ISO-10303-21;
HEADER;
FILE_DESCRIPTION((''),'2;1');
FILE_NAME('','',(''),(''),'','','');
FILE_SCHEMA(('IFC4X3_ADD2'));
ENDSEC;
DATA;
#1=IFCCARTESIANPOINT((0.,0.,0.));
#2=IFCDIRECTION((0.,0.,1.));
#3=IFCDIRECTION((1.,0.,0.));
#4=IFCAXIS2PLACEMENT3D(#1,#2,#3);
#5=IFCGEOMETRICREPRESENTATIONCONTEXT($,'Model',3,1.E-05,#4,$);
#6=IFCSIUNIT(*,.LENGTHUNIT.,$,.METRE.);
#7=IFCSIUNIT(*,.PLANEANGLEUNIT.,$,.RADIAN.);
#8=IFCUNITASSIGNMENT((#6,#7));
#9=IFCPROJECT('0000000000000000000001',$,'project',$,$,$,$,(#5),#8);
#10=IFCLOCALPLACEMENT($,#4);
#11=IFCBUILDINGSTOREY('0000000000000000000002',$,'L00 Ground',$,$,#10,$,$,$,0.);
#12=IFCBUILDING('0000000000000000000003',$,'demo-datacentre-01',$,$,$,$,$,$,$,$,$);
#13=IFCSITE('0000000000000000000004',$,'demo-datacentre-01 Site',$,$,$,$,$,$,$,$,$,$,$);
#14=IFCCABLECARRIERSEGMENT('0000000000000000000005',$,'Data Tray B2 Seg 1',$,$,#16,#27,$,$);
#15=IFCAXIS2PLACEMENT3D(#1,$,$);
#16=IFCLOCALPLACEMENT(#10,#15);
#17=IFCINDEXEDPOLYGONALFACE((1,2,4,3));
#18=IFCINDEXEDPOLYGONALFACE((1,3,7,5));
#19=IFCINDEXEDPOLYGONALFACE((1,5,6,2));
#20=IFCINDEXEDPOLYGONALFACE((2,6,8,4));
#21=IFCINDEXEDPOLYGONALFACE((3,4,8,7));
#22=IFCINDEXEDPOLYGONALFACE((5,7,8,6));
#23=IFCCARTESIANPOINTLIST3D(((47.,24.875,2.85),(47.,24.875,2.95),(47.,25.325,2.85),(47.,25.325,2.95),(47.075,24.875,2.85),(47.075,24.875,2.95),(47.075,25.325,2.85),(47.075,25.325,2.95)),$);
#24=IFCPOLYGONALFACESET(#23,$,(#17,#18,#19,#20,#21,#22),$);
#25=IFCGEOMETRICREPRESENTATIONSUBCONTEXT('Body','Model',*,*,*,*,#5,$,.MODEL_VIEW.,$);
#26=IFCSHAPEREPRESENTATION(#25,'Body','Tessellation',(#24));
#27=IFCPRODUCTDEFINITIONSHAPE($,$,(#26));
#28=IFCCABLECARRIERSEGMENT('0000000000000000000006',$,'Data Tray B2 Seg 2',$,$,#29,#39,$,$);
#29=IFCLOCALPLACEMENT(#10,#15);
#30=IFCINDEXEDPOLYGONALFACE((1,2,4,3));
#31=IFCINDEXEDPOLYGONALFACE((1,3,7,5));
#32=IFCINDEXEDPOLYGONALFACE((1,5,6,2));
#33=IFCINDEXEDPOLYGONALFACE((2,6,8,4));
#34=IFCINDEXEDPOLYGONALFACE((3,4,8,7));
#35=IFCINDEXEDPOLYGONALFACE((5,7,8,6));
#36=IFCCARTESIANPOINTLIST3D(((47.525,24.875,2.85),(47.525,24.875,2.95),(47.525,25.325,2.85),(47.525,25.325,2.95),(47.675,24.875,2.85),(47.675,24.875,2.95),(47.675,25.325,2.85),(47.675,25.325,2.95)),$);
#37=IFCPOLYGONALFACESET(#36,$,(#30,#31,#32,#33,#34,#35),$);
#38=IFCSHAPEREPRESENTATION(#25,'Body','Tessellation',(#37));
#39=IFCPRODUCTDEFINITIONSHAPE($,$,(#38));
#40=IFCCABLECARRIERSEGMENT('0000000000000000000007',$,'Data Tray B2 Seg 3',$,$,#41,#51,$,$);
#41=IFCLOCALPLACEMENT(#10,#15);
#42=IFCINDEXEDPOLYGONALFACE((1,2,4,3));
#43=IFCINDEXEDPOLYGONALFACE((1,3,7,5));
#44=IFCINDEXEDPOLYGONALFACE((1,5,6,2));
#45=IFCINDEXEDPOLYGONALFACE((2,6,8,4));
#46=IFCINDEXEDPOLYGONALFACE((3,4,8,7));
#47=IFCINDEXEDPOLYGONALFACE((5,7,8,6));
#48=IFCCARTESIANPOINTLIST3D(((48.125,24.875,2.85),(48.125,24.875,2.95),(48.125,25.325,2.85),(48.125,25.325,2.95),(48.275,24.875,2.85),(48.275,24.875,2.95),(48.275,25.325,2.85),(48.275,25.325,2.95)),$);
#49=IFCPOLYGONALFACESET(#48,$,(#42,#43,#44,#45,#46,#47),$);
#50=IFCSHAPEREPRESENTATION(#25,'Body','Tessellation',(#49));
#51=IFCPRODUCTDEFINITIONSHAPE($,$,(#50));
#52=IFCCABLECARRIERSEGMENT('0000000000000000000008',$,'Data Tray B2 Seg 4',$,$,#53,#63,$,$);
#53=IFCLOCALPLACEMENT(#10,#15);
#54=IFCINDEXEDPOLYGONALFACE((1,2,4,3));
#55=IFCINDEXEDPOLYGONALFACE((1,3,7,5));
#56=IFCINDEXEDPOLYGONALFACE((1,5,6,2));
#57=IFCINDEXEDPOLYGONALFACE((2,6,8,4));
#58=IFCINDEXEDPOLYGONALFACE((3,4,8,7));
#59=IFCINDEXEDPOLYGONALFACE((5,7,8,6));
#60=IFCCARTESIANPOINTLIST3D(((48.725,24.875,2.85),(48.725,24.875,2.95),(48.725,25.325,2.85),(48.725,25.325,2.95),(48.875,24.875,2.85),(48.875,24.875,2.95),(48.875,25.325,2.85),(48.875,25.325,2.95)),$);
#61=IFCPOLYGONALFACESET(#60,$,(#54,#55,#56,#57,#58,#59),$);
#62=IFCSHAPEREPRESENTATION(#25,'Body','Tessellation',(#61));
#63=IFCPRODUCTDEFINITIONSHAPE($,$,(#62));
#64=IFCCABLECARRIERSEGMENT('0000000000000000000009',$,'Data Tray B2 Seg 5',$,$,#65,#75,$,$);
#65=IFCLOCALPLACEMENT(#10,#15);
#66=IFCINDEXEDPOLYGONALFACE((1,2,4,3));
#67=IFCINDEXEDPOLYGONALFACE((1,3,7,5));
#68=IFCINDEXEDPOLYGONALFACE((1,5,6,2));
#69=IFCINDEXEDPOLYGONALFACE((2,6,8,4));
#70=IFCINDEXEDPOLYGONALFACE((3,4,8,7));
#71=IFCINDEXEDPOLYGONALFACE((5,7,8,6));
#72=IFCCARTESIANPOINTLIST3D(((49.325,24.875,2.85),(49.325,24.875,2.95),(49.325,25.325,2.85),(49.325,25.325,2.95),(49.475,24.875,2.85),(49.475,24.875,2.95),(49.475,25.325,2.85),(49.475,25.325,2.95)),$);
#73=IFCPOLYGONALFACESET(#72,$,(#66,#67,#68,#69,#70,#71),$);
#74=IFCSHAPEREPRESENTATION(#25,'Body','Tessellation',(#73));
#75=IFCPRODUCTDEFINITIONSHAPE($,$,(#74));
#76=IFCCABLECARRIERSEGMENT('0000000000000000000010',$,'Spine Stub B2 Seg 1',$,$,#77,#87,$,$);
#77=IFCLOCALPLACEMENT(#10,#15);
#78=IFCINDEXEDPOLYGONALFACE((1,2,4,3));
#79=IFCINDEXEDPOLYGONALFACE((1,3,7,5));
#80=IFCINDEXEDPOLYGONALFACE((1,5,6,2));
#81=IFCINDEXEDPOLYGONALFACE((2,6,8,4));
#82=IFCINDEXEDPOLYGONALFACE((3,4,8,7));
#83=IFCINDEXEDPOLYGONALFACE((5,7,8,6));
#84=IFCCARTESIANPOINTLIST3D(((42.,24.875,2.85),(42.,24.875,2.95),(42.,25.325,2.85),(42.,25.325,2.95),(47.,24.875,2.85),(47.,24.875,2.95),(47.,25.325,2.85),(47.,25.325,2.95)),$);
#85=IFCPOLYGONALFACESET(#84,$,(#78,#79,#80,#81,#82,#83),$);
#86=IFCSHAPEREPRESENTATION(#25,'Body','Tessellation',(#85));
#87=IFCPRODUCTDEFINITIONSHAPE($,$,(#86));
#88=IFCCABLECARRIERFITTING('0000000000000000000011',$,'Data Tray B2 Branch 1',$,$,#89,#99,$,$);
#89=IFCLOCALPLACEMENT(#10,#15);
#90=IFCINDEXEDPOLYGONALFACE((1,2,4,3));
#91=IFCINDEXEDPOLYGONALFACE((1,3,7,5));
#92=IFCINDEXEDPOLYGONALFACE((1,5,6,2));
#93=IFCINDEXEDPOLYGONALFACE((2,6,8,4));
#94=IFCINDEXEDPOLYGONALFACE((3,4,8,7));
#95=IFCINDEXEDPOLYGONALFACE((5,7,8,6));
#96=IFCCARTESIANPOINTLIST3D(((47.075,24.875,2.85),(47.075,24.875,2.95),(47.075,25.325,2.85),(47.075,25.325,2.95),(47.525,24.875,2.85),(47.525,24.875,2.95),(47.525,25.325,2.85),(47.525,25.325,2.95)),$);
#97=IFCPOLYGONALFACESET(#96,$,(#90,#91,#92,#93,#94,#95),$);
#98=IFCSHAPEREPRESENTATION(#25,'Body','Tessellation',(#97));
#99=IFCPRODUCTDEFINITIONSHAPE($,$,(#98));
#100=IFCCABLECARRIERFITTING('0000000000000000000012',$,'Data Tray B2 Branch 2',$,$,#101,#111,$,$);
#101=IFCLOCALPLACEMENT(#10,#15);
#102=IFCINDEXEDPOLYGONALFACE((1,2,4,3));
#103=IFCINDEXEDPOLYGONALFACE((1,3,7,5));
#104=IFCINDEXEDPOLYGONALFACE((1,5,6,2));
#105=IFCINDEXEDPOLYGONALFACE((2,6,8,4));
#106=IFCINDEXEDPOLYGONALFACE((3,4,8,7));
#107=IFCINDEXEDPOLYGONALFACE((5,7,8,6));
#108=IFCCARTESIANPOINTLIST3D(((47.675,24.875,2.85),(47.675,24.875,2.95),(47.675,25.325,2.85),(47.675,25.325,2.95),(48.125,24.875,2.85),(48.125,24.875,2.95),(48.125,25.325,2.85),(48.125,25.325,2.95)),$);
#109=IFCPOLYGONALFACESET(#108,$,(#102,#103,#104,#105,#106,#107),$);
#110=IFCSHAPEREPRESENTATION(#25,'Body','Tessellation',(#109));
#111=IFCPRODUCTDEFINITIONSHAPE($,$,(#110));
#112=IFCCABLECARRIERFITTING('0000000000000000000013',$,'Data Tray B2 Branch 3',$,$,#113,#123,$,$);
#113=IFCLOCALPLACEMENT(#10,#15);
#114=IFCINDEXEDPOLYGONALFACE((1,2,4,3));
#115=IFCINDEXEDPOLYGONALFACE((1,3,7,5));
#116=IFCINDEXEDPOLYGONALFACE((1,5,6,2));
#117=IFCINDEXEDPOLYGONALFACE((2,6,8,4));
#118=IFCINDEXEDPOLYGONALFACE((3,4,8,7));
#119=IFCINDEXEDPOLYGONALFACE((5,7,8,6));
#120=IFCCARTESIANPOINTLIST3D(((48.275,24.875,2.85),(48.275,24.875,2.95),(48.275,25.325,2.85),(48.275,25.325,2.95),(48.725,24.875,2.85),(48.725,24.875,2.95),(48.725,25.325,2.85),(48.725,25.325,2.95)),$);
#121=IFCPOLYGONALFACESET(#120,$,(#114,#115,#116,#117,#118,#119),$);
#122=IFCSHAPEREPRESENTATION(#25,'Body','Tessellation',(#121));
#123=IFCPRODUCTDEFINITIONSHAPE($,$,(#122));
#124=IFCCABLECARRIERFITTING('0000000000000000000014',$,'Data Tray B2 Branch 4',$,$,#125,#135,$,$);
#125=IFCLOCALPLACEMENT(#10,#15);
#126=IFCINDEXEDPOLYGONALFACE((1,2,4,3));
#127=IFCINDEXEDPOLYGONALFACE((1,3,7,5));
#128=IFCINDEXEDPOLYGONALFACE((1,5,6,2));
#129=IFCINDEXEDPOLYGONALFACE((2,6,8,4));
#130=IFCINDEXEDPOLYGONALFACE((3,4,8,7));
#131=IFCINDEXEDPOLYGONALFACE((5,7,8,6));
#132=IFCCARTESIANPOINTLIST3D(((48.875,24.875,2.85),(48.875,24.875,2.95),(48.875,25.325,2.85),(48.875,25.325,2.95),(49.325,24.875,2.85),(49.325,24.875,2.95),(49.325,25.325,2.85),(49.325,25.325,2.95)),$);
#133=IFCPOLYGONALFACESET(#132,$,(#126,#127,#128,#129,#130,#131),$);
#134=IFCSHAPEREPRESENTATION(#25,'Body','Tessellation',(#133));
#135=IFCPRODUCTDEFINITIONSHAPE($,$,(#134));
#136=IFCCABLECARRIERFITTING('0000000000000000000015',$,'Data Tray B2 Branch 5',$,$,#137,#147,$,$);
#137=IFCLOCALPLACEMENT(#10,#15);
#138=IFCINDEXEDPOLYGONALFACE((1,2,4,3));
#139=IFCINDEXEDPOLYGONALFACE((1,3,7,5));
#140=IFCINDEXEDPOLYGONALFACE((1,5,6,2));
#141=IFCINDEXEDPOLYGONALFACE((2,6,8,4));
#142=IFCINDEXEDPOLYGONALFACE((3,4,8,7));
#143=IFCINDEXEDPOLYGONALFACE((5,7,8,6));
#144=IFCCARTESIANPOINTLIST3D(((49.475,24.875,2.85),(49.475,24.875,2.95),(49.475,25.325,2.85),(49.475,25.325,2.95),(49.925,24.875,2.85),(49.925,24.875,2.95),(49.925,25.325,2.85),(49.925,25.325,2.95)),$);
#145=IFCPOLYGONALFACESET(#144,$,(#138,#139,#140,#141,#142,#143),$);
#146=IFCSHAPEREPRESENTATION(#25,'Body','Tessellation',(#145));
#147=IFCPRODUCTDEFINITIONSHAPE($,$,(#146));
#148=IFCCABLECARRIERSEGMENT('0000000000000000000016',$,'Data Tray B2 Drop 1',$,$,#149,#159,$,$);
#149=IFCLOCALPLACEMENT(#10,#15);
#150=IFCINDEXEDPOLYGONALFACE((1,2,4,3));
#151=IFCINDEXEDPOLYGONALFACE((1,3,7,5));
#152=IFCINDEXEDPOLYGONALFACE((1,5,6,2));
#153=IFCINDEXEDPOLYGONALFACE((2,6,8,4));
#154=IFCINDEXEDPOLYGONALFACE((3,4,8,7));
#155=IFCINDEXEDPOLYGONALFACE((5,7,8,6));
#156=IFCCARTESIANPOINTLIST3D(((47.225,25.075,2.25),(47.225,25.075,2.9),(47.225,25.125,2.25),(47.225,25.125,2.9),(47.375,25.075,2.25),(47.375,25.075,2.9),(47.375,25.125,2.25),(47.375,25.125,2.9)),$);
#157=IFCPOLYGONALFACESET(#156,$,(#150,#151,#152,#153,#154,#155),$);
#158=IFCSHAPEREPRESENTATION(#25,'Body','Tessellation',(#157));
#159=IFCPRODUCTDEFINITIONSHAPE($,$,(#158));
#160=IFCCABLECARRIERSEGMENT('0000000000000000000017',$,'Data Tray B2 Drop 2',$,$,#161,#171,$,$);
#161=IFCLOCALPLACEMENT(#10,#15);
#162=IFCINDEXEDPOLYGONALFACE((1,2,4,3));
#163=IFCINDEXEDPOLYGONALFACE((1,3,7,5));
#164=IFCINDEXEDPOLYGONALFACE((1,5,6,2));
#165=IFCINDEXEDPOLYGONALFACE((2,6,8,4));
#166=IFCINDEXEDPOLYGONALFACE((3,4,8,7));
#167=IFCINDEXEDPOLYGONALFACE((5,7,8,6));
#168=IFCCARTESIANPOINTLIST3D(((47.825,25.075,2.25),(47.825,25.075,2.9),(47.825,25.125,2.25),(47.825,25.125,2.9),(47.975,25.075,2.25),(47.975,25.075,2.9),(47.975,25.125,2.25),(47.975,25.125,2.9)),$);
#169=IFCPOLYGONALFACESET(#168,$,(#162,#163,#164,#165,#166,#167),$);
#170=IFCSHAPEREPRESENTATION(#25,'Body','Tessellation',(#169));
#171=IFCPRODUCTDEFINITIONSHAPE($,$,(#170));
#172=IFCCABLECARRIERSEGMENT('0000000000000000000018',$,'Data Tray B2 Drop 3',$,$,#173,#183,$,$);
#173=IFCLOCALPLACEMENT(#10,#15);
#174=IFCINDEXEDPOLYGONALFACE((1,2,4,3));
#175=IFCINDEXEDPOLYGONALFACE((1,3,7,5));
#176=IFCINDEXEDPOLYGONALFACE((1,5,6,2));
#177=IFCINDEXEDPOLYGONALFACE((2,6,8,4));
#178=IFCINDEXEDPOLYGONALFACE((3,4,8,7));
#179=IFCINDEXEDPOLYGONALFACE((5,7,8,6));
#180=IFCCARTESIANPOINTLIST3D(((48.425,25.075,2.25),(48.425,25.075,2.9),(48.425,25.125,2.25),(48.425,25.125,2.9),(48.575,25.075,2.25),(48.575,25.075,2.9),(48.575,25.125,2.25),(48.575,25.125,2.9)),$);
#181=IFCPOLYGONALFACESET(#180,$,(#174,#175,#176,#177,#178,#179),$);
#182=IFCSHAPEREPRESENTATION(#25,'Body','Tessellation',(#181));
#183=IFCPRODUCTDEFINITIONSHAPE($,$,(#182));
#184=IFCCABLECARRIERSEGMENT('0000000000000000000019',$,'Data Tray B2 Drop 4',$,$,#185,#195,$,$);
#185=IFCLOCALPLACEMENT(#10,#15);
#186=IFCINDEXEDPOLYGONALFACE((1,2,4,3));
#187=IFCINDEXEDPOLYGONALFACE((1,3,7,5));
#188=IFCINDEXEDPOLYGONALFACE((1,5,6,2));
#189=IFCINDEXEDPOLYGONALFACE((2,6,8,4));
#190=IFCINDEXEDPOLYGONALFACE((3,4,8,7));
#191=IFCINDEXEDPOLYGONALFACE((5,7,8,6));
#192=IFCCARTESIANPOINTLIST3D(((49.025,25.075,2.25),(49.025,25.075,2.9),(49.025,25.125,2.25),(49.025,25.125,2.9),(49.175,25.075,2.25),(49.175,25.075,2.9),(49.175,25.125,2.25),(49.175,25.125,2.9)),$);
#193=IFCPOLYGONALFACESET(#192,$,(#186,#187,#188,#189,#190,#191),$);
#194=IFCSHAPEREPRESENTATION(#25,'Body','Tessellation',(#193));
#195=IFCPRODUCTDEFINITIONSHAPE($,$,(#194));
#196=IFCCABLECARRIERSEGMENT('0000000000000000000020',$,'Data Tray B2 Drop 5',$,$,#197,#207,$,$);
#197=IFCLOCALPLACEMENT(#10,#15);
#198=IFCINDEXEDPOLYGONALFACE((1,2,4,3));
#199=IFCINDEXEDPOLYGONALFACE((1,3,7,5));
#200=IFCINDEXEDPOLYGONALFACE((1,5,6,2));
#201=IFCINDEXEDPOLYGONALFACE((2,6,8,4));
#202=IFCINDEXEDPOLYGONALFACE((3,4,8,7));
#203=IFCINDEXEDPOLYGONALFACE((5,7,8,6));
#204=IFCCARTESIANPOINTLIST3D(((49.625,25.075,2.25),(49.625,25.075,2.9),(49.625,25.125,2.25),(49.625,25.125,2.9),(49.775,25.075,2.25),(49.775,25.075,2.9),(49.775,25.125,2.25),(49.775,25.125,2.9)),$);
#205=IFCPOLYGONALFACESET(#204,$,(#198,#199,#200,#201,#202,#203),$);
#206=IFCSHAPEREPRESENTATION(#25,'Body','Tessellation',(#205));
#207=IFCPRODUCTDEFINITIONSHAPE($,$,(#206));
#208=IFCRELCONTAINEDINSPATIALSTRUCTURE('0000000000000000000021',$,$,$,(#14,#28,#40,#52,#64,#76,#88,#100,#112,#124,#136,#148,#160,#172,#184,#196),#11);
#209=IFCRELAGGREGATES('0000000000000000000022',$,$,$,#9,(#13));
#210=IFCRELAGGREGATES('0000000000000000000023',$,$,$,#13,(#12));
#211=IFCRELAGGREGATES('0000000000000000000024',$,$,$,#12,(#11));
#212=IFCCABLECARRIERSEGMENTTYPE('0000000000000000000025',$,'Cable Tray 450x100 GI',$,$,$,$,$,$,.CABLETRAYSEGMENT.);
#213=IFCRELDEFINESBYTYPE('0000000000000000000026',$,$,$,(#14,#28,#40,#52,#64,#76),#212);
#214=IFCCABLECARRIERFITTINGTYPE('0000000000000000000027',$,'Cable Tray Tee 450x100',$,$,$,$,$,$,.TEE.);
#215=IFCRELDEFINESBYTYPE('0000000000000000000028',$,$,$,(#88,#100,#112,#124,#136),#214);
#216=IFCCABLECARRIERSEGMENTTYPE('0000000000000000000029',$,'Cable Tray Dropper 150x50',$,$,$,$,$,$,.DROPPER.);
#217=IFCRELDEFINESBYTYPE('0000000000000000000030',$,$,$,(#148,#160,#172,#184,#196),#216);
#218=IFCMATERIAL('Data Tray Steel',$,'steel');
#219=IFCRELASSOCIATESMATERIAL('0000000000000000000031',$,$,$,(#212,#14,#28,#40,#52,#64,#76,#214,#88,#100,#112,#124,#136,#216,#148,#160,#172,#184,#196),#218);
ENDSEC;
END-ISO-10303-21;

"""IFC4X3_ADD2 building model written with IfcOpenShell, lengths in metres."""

from ifc_helpers import new_model, si_unit, frame, origin_with_axes, place, context, subcontext, project, spatial, rectangle, extrude, material, type_object, element, save


model = new_model("IFC4X3_ADD2")

# Units and contexts
model_context = context("Model", 3, precision=1e-05, world=origin_with_axes())
body_context = subcontext(model_context, "Body", "Model", "MODEL_VIEW")
ifc_project = project(units=[si_unit("LENGTHUNIT", "METRE"), si_unit("PLANEANGLEUNIT", "RADIAN")], contexts=[model_context])

# Site, building, storey
site = spatial("IfcSite", under=ifc_project, Name="demo-datacentre-01 Site")
building = spatial("IfcBuilding", under=site, Name="demo-datacentre-01")
storey_placement = place(None, origin_with_axes())
storey = spatial("IfcBuildingStorey", under=building, at=storey_placement, Name="L00 Ground", Elevation=0.0)

# Cable carrier segments
ifc_material_1 = material(Name="Data Tray Steel", Category="steel")
cable_carrier_segment_type_1 = type_object("IfcCableCarrierSegmentType", Name="Cable Tray 450x100 GI", PredefinedType="CABLETRAYSEGMENT", material=ifc_material_1)
cable_carrier_segment_1_placement = place(storey_placement, frame((47.0, 25.1, 2.9), z_axis=(1.0, 0.0, 0.0), x_axis=(0.0, 1.0, 0.0)))
element("IfcCableCarrierSegment", 1, at=cable_carrier_segment_1_placement, inside=storey, type_object=cable_carrier_segment_type_1, material=ifc_material_1, Name="Data Tray B2 Seg 1", context=body_context, shape_type="SweptSolid", body=[
    extrude(rectangle(XDim=0.45, YDim=0.1), origin_with_axes(), (0.0, 0.0, 1.0), 0.075),
])
for number, where, z_axis, x_axis, name in (
    (2, (47.525, 25.1, 2.9), (1.0, 0.0, 0.0), (0.0, 1.0, 0.0), "Data Tray B2 Seg 2"),
    (3, (48.125, 25.1, 2.9), (1.0, 0.0, 0.0), (0.0, 1.0, 0.0), "Data Tray B2 Seg 3"),
):
    element("IfcCableCarrierSegment", number, at=place(storey_placement, frame(where, z_axis=z_axis, x_axis=x_axis)), inside=storey, type_object=cable_carrier_segment_type_1, material=ifc_material_1, Name=name, context=body_context, shape_type="SweptSolid", body=[
        extrude(rectangle(XDim=0.45, YDim=0.1), origin_with_axes(), (0.0, 0.0, 1.0), 0.15),
    ])
cable_carrier_segment_2_placement = place(storey_placement, frame((48.725, 25.1, 2.9), z_axis=(1.0, 0.0, 0.0), x_axis=(0.0, 1.0, 0.0)))
element("IfcCableCarrierSegment", 4, at=cable_carrier_segment_2_placement, inside=storey, type_object=cable_carrier_segment_type_1, material=ifc_material_1, Name="Data Tray B2 Seg 4", context=body_context, shape_type="SweptSolid", body=[
    extrude(rectangle(XDim=0.45, YDim=0.1), origin_with_axes(), (0.0, 0.0, 1.0), 0.15),
])
cable_carrier_segment_3_placement = place(storey_placement, frame((49.325, 25.1, 2.9), z_axis=(1.0, 0.0, 0.0), x_axis=(0.0, 1.0, 0.0)))
element("IfcCableCarrierSegment", 5, at=cable_carrier_segment_3_placement, inside=storey, type_object=cable_carrier_segment_type_1, material=ifc_material_1, Name="Data Tray B2 Seg 5", context=body_context, shape_type="SweptSolid", body=[
    extrude(rectangle(XDim=0.45, YDim=0.1), origin_with_axes(), (0.0, 0.0, 1.0), 0.15),
])
cable_carrier_segment_4_placement = place(storey_placement, frame((42.0, 25.1, 2.9), z_axis=(1.0, 0.0, 0.0), x_axis=(0.0, 1.0, 0.0)))
element("IfcCableCarrierSegment", 6, at=cable_carrier_segment_4_placement, inside=storey, type_object=cable_carrier_segment_type_1, material=ifc_material_1, Name="Spine Stub B2 Seg 1", context=body_context, shape_type="SweptSolid", body=[
    extrude(rectangle(XDim=0.45, YDim=0.1), origin_with_axes(), (0.0, 0.0, 1.0), 5.0),
])

# Cable carrier fittings
cable_carrier_fitting_type = type_object("IfcCableCarrierFittingType", Name="Cable Tray Tee 450x100", PredefinedType="TEE", material=ifc_material_1)
for number, where, z_axis, x_axis, name in (
    (7, (47.3, 25.1, 2.85), (0.0, 0.0, 1.0), (1.0, 0.0, 0.0), "Data Tray B2 Branch 1"),
    (8, (47.9, 25.1, 2.85), (0.0, 0.0, 1.0), (1.0, 0.0, 0.0), "Data Tray B2 Branch 2"),
    (9, (48.5, 25.1, 2.85), (0.0, 0.0, 1.0), (1.0, 0.0, 0.0), "Data Tray B2 Branch 3"),
    (10, (49.1, 25.1, 2.85), (0.0, 0.0, 1.0), (1.0, 0.0, 0.0), "Data Tray B2 Branch 4"),
    (11, (49.7, 25.1, 2.85), (0.0, 0.0, 1.0), (1.0, 0.0, 0.0), "Data Tray B2 Branch 5"),
):
    element("IfcCableCarrierFitting", number, at=place(storey_placement, frame(where, z_axis=z_axis, x_axis=x_axis)), inside=storey, type_object=cable_carrier_fitting_type, material=ifc_material_1, Name=name, context=body_context, shape_type="SweptSolid", body=[
        extrude(rectangle(XDim=0.45, YDim=0.45), origin_with_axes(), (0.0, 0.0, 1.0), 0.1),
    ])

# Cable carrier segments
cable_carrier_segment_type_2 = type_object("IfcCableCarrierSegmentType", Name="Cable Tray Dropper 150x50", PredefinedType="DROPPER", material=ifc_material_1)
for number, where, z_axis, x_axis, name in (
    (12, (47.3, 25.1, 2.9), (0.0, 0.0, -1.0), (1.0, 0.0, 0.0), "Data Tray B2 Drop 1"),
    (13, (47.9, 25.1, 2.9), (0.0, 0.0, -1.0), (1.0, 0.0, 0.0), "Data Tray B2 Drop 2"),
    (14, (48.5, 25.1, 2.9), (0.0, 0.0, -1.0), (1.0, 0.0, 0.0), "Data Tray B2 Drop 3"),
    (15, (49.1, 25.1, 2.9), (0.0, 0.0, -1.0), (1.0, 0.0, 0.0), "Data Tray B2 Drop 4"),
    (16, (49.7, 25.1, 2.9), (0.0, 0.0, -1.0), (1.0, 0.0, 0.0), "Data Tray B2 Drop 5"),
):
    element("IfcCableCarrierSegment", number, at=place(storey_placement, frame(where, z_axis=z_axis, x_axis=x_axis)), inside=storey, type_object=cable_carrier_segment_type_2, material=ifc_material_1, Name=name, context=body_context, shape_type="SweptSolid", body=[
        extrude(rectangle(XDim=0.15, YDim=0.05), origin_with_axes(), (0.0, 0.0, 1.0), 0.65),
    ])

save(model, "model.ifc")
